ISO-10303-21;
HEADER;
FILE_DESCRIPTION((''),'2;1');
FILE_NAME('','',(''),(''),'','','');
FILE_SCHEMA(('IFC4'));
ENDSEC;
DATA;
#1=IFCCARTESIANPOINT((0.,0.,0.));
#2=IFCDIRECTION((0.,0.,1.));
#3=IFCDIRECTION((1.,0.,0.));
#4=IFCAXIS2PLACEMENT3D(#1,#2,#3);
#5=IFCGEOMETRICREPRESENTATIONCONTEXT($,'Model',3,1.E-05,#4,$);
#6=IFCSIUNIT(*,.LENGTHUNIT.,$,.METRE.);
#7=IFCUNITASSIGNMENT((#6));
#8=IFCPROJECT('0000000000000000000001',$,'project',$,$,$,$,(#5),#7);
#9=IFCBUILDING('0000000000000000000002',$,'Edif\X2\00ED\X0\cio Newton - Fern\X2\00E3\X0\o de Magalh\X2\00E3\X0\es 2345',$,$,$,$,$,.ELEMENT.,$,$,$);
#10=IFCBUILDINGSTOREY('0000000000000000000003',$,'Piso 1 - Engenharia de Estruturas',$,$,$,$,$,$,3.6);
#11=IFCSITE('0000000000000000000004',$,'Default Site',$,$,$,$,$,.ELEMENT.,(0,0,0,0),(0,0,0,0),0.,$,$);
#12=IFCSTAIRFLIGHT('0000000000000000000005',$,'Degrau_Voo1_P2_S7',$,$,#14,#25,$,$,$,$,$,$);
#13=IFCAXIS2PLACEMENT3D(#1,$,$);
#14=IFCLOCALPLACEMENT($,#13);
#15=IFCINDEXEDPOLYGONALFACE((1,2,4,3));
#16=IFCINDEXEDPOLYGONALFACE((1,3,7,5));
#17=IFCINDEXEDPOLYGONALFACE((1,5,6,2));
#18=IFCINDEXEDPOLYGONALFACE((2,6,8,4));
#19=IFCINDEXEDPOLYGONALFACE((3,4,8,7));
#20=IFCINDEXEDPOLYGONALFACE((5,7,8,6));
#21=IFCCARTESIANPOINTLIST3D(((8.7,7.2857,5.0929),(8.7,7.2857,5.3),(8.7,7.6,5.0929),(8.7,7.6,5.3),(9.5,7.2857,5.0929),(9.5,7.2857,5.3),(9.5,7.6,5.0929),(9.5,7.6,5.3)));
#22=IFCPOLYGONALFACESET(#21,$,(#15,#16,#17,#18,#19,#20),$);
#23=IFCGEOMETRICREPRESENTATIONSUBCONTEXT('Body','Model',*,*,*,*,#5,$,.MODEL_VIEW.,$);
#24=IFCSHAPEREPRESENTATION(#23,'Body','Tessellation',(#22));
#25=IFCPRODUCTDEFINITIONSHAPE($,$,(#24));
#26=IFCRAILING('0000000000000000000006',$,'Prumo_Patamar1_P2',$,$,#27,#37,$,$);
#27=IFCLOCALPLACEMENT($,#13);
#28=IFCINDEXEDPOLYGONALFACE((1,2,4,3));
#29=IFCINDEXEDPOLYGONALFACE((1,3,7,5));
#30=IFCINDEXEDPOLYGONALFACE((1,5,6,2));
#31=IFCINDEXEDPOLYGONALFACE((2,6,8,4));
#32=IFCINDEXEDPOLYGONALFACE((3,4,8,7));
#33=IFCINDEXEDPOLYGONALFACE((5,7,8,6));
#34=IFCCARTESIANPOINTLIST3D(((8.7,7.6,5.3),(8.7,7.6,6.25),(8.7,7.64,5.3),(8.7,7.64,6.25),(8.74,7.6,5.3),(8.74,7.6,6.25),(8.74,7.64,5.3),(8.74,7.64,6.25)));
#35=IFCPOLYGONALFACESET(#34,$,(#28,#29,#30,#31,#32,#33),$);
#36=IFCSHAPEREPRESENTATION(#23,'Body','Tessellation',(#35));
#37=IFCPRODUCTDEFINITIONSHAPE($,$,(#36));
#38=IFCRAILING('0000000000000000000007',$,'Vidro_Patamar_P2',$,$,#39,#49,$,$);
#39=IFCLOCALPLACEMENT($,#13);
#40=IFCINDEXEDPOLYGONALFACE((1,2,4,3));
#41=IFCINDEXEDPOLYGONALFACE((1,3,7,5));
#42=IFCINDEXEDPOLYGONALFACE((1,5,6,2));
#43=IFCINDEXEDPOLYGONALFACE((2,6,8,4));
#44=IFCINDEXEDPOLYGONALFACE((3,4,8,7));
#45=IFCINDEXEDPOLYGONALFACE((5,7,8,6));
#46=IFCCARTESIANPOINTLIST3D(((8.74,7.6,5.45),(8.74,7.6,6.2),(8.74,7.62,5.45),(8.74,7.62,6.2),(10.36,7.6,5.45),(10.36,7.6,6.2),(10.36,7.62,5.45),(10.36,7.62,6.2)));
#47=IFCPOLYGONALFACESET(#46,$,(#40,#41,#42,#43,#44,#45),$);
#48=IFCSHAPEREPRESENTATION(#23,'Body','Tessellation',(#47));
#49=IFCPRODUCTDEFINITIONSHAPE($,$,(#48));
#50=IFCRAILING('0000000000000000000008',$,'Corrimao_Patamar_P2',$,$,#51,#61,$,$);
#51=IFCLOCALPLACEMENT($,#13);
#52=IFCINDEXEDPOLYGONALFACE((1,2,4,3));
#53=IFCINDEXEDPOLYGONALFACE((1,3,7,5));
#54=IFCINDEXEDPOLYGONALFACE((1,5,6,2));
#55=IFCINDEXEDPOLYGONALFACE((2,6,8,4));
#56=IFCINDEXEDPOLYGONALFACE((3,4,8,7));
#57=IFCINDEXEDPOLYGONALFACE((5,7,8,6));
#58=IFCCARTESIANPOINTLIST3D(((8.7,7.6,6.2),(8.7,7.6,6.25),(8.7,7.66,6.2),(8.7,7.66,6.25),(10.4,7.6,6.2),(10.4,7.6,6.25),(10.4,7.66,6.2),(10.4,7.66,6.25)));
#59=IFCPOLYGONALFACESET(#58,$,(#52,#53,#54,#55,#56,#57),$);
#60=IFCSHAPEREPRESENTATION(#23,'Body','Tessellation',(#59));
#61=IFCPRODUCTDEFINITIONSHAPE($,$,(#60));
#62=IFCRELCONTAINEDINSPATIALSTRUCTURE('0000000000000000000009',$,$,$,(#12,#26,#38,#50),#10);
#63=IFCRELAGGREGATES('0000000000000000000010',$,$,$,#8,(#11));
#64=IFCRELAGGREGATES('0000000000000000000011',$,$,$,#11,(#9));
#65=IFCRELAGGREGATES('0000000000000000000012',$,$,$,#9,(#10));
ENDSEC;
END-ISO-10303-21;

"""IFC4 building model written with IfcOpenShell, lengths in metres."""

from ifc_helpers import new_model, si_unit, frame, frame_2d, origin_with_axes, place, context, subcontext, project, spatial, rectangle, extrude, element, save


model = new_model("IFC4")

# Units and contexts
model_context = context("Model", 3, precision=1e-05, world=origin_with_axes())
body_context = subcontext(model_context, "Body", "Model", "MODEL_VIEW")
ifc_project = project(units=[si_unit("LENGTHUNIT", "METRE")], contexts=[model_context])

# Site, building, storey
site = spatial("IfcSite", under=ifc_project, Name="Default Site", CompositionType="ELEMENT", RefLatitude=(0, 0, 0, 0), RefLongitude=(0, 0, 0, 0), RefElevation=0.0)
building = spatial("IfcBuilding", under=site, Name="Edifício Newton - Fernão de Magalhães 2345", CompositionType="ELEMENT")
storey = spatial("IfcBuildingStorey", under=building, Name="Piso 1 - Engenharia de Estruturas", Elevation=3.6)

# Stair flight
for number, where, z_axis, x_axis, name in (
    (1, (8.7, 7.2857, 5.0929), (0.0, 0.0, 1.0), (1.0, 0.0, 0.0), "Degrau_Voo1_P2_S7"),
):
    element("IfcStairFlight", number, at=place(None, frame(where, z_axis=z_axis, x_axis=x_axis)), inside=storey, Name=name, context=body_context, shape_type="SweptSolid", body=[
        extrude(rectangle(XDim=0.8, YDim=0.3143, at=frame_2d((0.4, 0.1571))), origin_with_axes(), (0.0, 0.0, 1.0), 0.2071),
    ])

# Railings
railing_1_placement = place(None, frame((8.7, 7.6, 5.3), z_axis=(0.0, 0.0, 1.0), x_axis=(1.0, 0.0, 0.0)))
element("IfcRailing", 2, at=railing_1_placement, inside=storey, Name="Prumo_Patamar1_P2", context=body_context, shape_type="SweptSolid", body=[
    extrude(rectangle(XDim=0.04, YDim=0.04, at=frame_2d((0.02, 0.02))), origin_with_axes(), (0.0, 0.0, 1.0), 0.95),
])
railing_2_placement = place(None, frame((8.74, 7.6, 5.45), z_axis=(0.0, 0.0, 1.0), x_axis=(1.0, 0.0, 0.0)))
element("IfcRailing", 3, at=railing_2_placement, inside=storey, Name="Vidro_Patamar_P2", context=body_context, shape_type="SweptSolid", body=[
    extrude(rectangle(XDim=1.62, YDim=0.02, at=frame_2d((0.81, 0.01))), origin_with_axes(), (0.0, 0.0, 1.0), 0.75),
])
railing_3_placement = place(None, frame((8.7, 7.6, 6.2), z_axis=(0.0, 0.0, 1.0), x_axis=(1.0, 0.0, 0.0)))
element("IfcRailing", 4, at=railing_3_placement, inside=storey, Name="Corrimao_Patamar_P2", context=body_context, shape_type="SweptSolid", body=[
    extrude(rectangle(XDim=1.7, YDim=0.06, at=frame_2d((0.85, 0.03))), origin_with_axes(), (0.0, 0.0, 1.0), 0.05),
])

save(model, "model.ifc")
